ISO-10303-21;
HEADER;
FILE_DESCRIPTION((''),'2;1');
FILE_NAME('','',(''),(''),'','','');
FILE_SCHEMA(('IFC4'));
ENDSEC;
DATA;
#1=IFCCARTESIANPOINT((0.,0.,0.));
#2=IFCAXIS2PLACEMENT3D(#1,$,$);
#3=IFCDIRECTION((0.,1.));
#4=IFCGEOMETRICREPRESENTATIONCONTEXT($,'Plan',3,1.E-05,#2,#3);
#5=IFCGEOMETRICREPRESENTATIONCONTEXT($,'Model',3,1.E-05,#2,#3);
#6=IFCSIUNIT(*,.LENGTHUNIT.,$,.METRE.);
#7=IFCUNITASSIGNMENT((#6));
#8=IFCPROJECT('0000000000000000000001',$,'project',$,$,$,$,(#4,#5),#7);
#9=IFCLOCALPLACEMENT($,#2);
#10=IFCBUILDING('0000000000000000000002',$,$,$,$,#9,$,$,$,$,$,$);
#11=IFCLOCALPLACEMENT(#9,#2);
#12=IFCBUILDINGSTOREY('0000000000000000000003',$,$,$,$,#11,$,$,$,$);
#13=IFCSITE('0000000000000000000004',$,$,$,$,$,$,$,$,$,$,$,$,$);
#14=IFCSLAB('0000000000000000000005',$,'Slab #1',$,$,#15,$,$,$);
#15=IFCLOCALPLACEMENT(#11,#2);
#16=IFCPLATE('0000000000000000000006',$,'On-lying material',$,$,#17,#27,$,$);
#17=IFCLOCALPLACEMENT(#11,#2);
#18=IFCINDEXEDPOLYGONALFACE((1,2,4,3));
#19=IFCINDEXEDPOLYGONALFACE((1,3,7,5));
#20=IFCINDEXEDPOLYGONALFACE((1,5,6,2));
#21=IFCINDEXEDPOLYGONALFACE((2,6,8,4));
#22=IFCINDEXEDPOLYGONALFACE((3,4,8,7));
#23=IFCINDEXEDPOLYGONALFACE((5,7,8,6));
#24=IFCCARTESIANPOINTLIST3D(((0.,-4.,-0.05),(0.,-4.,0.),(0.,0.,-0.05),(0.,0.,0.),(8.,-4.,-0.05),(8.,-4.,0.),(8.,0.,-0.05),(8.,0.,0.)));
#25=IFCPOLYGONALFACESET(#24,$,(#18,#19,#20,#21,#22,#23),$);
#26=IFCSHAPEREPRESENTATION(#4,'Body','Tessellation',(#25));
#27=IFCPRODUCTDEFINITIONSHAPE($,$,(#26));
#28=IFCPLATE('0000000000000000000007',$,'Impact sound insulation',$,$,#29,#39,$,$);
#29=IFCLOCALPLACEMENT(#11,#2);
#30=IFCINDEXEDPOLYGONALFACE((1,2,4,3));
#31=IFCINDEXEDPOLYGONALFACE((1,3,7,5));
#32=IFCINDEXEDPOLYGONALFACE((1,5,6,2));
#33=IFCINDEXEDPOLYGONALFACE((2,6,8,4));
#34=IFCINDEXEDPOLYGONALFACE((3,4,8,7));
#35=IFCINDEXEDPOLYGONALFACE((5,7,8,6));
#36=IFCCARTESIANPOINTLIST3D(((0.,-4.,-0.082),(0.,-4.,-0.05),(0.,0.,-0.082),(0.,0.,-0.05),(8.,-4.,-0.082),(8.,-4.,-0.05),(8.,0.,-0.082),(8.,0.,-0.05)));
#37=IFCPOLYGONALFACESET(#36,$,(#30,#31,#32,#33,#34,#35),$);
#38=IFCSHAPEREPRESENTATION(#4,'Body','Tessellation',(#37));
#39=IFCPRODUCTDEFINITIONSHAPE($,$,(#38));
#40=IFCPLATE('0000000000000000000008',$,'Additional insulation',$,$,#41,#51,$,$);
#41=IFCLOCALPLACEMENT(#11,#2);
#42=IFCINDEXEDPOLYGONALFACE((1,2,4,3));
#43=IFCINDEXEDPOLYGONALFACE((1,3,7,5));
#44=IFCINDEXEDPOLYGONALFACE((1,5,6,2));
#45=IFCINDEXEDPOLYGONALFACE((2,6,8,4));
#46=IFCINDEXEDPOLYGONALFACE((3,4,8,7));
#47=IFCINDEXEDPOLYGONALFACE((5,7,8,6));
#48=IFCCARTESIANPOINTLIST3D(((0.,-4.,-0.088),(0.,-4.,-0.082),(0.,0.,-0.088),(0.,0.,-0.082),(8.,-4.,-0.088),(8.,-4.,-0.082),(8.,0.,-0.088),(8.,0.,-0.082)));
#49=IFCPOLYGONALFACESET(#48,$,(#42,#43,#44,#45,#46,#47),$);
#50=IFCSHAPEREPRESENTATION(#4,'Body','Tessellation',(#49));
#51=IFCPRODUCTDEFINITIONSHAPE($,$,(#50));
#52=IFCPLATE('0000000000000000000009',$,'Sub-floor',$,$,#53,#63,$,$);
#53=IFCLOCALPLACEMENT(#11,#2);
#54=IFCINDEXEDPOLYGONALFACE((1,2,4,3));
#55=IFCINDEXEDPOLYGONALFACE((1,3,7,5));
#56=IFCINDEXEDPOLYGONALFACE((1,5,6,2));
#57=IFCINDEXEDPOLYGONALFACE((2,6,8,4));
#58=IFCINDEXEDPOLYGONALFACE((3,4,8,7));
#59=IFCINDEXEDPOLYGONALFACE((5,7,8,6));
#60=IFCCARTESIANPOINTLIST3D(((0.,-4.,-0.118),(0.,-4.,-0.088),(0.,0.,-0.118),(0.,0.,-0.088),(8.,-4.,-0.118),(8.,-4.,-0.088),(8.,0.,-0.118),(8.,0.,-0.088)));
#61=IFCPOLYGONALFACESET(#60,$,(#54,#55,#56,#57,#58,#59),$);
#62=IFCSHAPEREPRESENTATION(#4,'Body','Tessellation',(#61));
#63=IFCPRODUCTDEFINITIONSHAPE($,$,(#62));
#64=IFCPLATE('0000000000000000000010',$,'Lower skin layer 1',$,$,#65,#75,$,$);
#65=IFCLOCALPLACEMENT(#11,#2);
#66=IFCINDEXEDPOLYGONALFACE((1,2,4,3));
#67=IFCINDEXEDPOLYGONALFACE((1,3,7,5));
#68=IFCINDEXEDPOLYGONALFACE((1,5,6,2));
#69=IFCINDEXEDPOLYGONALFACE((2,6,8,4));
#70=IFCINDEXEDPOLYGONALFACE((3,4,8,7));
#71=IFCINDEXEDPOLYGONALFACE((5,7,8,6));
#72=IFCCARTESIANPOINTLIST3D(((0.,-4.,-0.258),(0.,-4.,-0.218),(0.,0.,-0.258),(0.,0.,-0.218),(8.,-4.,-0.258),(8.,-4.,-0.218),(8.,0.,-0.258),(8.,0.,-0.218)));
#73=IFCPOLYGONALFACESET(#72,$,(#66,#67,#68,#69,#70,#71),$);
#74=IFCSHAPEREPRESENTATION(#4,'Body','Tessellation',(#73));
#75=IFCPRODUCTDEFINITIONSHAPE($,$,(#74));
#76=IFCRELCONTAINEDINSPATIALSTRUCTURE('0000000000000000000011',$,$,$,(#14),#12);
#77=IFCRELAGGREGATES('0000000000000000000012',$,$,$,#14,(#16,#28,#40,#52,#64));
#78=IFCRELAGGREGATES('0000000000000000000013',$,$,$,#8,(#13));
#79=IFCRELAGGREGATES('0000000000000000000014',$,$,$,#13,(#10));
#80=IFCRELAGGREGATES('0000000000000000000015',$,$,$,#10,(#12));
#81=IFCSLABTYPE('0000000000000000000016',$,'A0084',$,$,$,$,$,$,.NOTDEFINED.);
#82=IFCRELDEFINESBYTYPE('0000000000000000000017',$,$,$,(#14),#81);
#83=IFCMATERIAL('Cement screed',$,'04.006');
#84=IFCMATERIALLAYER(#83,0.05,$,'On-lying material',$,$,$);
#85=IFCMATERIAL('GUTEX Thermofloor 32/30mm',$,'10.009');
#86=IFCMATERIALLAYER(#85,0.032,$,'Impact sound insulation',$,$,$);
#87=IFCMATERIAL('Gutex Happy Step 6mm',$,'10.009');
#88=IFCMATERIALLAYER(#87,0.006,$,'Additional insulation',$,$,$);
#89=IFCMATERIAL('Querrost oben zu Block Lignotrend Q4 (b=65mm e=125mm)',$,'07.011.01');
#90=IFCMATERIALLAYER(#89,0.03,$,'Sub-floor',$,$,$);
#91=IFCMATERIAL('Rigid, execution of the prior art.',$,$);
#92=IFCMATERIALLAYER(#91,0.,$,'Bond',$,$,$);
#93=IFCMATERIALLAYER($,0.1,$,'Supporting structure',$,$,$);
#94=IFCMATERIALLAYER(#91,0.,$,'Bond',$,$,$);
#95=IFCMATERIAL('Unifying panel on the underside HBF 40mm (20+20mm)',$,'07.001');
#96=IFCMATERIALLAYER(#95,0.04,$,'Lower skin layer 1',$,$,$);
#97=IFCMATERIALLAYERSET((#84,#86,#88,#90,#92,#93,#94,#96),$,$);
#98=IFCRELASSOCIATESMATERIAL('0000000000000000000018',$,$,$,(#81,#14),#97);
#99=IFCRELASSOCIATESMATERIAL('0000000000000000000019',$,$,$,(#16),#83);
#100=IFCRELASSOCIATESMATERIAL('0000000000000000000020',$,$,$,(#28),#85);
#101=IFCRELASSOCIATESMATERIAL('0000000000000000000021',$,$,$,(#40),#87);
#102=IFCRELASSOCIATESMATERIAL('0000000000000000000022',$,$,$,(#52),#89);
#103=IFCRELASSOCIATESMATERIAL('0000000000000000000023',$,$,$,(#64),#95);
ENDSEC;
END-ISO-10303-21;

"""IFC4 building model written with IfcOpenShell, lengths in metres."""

from ifc_helpers import new_model, si_unit, direction, frame, frame_2d, origin, origin_with_axes, place, context, project, spatial, rectangle, extrude, material, layer, layer_set, type_object, element, aggregate, save


model = new_model("IFC4")

# Units and contexts
plan_context = context("Plan", 3, precision=1e-05, world=origin(), true_north=direction((0.0, 1.0)))
model_context = context("Model", 3, precision=1e-05, world=origin(), true_north=direction((0.0, 1.0)))
ifc_project = project(units=[si_unit("LENGTHUNIT", "METRE")], contexts=[plan_context, model_context])

# Site, building, storey
site = spatial("IfcSite", under=ifc_project)
building_placement = place(None, origin())
building = spatial("IfcBuilding", under=site, at=building_placement)
storey_placement = place(building_placement, origin())
storey = spatial("IfcBuildingStorey", under=building, at=storey_placement)

# Slab, plates
ifc_material_1 = material(Name="Cement screed", Category="04.006")
ifc_layer_1 = layer(ifc_material_1, 0.05, Name="On-lying material")
ifc_material_2 = material(Name="GUTEX Thermofloor 32/30mm", Category="10.009")
ifc_layer_2 = layer(ifc_material_2, 0.032, Name="Impact sound insulation")
ifc_material_3 = material(Name="Gutex Happy Step 6mm", Category="10.009")
ifc_layer_3 = layer(ifc_material_3, 0.006, Name="Additional insulation")
ifc_material_4 = material(Name="Querrost oben zu Block Lignotrend Q4 (b=65mm e=125mm)", Category="07.011.01")
ifc_layer_4 = layer(ifc_material_4, 0.03, Name="Sub-floor")
ifc_material_5 = material(Name="Rigid, execution of the prior art.")
ifc_layer_5 = layer(ifc_material_5, 0.0, Name="Bond")
ifc_layer_6 = layer(None, 0.1, Name="Supporting structure")
ifc_layer_7 = layer(ifc_material_5, 0.0, Name="Bond")
ifc_material_6 = material(Name="Unifying panel on the underside HBF 40mm (20+20mm)", Category="07.001")
ifc_layer_8 = layer(ifc_material_6, 0.04, Name="Lower skin layer 1")
ifc_layer_set = layer_set([ifc_layer_1, ifc_layer_2, ifc_layer_3, ifc_layer_4, ifc_layer_5, ifc_layer_6, ifc_layer_7, ifc_layer_8])
slab_type = type_object("IfcSlabType", Name="A0084", PredefinedType="NOTDEFINED", material=ifc_layer_set)
slab_placement = place(None, frame((0.0, 0.0, 0.0), z_axis=(0.0, 0.0, -1.0), x_axis=(1.0, 0.0, 0.0)))
slab = element("IfcSlab", 1, at=slab_placement, inside=storey, type_object=slab_type, material=ifc_layer_set, Name="Slab #1")
plate_1_placement = place(slab_placement, origin())
plate_1 = element("IfcPlate", 2, at=plate_1_placement, material=ifc_material_1, Name="On-lying material", context=plan_context, shape_type="SweptSolid", body=[
    extrude(rectangle(XDim=8.0, YDim=4.0, at=frame_2d((4.0, 2.0), x_axis=(1.0, 0.0))), origin_with_axes(), (0.0, 0.0, 1.0), 0.05),
])
plate_2_placement = place(slab_placement, origin())
plate_2 = element("IfcPlate", 3, at=plate_2_placement, material=ifc_material_2, Name="Impact sound insulation", context=plan_context, shape_type="SweptSolid", body=[
    extrude(rectangle(XDim=8.0, YDim=4.0, at=frame_2d((4.0, 2.0), x_axis=(1.0, 0.0))), frame((0.0, 0.0, 0.05), z_axis=(0.0, 0.0, 1.0), x_axis=(1.0, 0.0, 0.0)), (0.0, 0.0, 1.0), 0.032),
])
plate_3_placement = place(slab_placement, origin())
plate_3 = element("IfcPlate", 4, at=plate_3_placement, material=ifc_material_3, Name="Additional insulation", context=plan_context, shape_type="SweptSolid", body=[
    extrude(rectangle(XDim=8.0, YDim=4.0, at=frame_2d((4.0, 2.0), x_axis=(1.0, 0.0))), frame((0.0, 0.0, 0.082), z_axis=(0.0, 0.0, 1.0), x_axis=(1.0, 0.0, 0.0)), (0.0, 0.0, 1.0), 0.006),
])
plate_4_placement = place(slab_placement, origin())
plate_4 = element("IfcPlate", 5, at=plate_4_placement, material=ifc_material_4, Name="Sub-floor", context=plan_context, shape_type="SweptSolid", body=[
    extrude(rectangle(XDim=8.0, YDim=4.0, at=frame_2d((4.0, 2.0), x_axis=(1.0, 0.0))), frame((0.0, 0.0, 0.088), z_axis=(0.0, 0.0, 1.0), x_axis=(1.0, 0.0, 0.0)), (0.0, 0.0, 1.0), 0.03),
])
plate_5_placement = place(slab_placement, origin())
plate_5 = element("IfcPlate", 6, at=plate_5_placement, material=ifc_material_6, Name="Lower skin layer 1", context=plan_context, shape_type="SweptSolid", body=[
    extrude(rectangle(XDim=8.0, YDim=4.0, at=frame_2d((4.0, 2.0), x_axis=(1.0, 0.0))), frame((0.0, 0.0, 0.218), z_axis=(0.0, 0.0, 1.0), x_axis=(1.0, 0.0, 0.0)), (0.0, 0.0, 1.0), 0.04),
])
aggregate(slab, [plate_1, plate_2, plate_3, plate_4, plate_5])

save(model, "model.ifc")
